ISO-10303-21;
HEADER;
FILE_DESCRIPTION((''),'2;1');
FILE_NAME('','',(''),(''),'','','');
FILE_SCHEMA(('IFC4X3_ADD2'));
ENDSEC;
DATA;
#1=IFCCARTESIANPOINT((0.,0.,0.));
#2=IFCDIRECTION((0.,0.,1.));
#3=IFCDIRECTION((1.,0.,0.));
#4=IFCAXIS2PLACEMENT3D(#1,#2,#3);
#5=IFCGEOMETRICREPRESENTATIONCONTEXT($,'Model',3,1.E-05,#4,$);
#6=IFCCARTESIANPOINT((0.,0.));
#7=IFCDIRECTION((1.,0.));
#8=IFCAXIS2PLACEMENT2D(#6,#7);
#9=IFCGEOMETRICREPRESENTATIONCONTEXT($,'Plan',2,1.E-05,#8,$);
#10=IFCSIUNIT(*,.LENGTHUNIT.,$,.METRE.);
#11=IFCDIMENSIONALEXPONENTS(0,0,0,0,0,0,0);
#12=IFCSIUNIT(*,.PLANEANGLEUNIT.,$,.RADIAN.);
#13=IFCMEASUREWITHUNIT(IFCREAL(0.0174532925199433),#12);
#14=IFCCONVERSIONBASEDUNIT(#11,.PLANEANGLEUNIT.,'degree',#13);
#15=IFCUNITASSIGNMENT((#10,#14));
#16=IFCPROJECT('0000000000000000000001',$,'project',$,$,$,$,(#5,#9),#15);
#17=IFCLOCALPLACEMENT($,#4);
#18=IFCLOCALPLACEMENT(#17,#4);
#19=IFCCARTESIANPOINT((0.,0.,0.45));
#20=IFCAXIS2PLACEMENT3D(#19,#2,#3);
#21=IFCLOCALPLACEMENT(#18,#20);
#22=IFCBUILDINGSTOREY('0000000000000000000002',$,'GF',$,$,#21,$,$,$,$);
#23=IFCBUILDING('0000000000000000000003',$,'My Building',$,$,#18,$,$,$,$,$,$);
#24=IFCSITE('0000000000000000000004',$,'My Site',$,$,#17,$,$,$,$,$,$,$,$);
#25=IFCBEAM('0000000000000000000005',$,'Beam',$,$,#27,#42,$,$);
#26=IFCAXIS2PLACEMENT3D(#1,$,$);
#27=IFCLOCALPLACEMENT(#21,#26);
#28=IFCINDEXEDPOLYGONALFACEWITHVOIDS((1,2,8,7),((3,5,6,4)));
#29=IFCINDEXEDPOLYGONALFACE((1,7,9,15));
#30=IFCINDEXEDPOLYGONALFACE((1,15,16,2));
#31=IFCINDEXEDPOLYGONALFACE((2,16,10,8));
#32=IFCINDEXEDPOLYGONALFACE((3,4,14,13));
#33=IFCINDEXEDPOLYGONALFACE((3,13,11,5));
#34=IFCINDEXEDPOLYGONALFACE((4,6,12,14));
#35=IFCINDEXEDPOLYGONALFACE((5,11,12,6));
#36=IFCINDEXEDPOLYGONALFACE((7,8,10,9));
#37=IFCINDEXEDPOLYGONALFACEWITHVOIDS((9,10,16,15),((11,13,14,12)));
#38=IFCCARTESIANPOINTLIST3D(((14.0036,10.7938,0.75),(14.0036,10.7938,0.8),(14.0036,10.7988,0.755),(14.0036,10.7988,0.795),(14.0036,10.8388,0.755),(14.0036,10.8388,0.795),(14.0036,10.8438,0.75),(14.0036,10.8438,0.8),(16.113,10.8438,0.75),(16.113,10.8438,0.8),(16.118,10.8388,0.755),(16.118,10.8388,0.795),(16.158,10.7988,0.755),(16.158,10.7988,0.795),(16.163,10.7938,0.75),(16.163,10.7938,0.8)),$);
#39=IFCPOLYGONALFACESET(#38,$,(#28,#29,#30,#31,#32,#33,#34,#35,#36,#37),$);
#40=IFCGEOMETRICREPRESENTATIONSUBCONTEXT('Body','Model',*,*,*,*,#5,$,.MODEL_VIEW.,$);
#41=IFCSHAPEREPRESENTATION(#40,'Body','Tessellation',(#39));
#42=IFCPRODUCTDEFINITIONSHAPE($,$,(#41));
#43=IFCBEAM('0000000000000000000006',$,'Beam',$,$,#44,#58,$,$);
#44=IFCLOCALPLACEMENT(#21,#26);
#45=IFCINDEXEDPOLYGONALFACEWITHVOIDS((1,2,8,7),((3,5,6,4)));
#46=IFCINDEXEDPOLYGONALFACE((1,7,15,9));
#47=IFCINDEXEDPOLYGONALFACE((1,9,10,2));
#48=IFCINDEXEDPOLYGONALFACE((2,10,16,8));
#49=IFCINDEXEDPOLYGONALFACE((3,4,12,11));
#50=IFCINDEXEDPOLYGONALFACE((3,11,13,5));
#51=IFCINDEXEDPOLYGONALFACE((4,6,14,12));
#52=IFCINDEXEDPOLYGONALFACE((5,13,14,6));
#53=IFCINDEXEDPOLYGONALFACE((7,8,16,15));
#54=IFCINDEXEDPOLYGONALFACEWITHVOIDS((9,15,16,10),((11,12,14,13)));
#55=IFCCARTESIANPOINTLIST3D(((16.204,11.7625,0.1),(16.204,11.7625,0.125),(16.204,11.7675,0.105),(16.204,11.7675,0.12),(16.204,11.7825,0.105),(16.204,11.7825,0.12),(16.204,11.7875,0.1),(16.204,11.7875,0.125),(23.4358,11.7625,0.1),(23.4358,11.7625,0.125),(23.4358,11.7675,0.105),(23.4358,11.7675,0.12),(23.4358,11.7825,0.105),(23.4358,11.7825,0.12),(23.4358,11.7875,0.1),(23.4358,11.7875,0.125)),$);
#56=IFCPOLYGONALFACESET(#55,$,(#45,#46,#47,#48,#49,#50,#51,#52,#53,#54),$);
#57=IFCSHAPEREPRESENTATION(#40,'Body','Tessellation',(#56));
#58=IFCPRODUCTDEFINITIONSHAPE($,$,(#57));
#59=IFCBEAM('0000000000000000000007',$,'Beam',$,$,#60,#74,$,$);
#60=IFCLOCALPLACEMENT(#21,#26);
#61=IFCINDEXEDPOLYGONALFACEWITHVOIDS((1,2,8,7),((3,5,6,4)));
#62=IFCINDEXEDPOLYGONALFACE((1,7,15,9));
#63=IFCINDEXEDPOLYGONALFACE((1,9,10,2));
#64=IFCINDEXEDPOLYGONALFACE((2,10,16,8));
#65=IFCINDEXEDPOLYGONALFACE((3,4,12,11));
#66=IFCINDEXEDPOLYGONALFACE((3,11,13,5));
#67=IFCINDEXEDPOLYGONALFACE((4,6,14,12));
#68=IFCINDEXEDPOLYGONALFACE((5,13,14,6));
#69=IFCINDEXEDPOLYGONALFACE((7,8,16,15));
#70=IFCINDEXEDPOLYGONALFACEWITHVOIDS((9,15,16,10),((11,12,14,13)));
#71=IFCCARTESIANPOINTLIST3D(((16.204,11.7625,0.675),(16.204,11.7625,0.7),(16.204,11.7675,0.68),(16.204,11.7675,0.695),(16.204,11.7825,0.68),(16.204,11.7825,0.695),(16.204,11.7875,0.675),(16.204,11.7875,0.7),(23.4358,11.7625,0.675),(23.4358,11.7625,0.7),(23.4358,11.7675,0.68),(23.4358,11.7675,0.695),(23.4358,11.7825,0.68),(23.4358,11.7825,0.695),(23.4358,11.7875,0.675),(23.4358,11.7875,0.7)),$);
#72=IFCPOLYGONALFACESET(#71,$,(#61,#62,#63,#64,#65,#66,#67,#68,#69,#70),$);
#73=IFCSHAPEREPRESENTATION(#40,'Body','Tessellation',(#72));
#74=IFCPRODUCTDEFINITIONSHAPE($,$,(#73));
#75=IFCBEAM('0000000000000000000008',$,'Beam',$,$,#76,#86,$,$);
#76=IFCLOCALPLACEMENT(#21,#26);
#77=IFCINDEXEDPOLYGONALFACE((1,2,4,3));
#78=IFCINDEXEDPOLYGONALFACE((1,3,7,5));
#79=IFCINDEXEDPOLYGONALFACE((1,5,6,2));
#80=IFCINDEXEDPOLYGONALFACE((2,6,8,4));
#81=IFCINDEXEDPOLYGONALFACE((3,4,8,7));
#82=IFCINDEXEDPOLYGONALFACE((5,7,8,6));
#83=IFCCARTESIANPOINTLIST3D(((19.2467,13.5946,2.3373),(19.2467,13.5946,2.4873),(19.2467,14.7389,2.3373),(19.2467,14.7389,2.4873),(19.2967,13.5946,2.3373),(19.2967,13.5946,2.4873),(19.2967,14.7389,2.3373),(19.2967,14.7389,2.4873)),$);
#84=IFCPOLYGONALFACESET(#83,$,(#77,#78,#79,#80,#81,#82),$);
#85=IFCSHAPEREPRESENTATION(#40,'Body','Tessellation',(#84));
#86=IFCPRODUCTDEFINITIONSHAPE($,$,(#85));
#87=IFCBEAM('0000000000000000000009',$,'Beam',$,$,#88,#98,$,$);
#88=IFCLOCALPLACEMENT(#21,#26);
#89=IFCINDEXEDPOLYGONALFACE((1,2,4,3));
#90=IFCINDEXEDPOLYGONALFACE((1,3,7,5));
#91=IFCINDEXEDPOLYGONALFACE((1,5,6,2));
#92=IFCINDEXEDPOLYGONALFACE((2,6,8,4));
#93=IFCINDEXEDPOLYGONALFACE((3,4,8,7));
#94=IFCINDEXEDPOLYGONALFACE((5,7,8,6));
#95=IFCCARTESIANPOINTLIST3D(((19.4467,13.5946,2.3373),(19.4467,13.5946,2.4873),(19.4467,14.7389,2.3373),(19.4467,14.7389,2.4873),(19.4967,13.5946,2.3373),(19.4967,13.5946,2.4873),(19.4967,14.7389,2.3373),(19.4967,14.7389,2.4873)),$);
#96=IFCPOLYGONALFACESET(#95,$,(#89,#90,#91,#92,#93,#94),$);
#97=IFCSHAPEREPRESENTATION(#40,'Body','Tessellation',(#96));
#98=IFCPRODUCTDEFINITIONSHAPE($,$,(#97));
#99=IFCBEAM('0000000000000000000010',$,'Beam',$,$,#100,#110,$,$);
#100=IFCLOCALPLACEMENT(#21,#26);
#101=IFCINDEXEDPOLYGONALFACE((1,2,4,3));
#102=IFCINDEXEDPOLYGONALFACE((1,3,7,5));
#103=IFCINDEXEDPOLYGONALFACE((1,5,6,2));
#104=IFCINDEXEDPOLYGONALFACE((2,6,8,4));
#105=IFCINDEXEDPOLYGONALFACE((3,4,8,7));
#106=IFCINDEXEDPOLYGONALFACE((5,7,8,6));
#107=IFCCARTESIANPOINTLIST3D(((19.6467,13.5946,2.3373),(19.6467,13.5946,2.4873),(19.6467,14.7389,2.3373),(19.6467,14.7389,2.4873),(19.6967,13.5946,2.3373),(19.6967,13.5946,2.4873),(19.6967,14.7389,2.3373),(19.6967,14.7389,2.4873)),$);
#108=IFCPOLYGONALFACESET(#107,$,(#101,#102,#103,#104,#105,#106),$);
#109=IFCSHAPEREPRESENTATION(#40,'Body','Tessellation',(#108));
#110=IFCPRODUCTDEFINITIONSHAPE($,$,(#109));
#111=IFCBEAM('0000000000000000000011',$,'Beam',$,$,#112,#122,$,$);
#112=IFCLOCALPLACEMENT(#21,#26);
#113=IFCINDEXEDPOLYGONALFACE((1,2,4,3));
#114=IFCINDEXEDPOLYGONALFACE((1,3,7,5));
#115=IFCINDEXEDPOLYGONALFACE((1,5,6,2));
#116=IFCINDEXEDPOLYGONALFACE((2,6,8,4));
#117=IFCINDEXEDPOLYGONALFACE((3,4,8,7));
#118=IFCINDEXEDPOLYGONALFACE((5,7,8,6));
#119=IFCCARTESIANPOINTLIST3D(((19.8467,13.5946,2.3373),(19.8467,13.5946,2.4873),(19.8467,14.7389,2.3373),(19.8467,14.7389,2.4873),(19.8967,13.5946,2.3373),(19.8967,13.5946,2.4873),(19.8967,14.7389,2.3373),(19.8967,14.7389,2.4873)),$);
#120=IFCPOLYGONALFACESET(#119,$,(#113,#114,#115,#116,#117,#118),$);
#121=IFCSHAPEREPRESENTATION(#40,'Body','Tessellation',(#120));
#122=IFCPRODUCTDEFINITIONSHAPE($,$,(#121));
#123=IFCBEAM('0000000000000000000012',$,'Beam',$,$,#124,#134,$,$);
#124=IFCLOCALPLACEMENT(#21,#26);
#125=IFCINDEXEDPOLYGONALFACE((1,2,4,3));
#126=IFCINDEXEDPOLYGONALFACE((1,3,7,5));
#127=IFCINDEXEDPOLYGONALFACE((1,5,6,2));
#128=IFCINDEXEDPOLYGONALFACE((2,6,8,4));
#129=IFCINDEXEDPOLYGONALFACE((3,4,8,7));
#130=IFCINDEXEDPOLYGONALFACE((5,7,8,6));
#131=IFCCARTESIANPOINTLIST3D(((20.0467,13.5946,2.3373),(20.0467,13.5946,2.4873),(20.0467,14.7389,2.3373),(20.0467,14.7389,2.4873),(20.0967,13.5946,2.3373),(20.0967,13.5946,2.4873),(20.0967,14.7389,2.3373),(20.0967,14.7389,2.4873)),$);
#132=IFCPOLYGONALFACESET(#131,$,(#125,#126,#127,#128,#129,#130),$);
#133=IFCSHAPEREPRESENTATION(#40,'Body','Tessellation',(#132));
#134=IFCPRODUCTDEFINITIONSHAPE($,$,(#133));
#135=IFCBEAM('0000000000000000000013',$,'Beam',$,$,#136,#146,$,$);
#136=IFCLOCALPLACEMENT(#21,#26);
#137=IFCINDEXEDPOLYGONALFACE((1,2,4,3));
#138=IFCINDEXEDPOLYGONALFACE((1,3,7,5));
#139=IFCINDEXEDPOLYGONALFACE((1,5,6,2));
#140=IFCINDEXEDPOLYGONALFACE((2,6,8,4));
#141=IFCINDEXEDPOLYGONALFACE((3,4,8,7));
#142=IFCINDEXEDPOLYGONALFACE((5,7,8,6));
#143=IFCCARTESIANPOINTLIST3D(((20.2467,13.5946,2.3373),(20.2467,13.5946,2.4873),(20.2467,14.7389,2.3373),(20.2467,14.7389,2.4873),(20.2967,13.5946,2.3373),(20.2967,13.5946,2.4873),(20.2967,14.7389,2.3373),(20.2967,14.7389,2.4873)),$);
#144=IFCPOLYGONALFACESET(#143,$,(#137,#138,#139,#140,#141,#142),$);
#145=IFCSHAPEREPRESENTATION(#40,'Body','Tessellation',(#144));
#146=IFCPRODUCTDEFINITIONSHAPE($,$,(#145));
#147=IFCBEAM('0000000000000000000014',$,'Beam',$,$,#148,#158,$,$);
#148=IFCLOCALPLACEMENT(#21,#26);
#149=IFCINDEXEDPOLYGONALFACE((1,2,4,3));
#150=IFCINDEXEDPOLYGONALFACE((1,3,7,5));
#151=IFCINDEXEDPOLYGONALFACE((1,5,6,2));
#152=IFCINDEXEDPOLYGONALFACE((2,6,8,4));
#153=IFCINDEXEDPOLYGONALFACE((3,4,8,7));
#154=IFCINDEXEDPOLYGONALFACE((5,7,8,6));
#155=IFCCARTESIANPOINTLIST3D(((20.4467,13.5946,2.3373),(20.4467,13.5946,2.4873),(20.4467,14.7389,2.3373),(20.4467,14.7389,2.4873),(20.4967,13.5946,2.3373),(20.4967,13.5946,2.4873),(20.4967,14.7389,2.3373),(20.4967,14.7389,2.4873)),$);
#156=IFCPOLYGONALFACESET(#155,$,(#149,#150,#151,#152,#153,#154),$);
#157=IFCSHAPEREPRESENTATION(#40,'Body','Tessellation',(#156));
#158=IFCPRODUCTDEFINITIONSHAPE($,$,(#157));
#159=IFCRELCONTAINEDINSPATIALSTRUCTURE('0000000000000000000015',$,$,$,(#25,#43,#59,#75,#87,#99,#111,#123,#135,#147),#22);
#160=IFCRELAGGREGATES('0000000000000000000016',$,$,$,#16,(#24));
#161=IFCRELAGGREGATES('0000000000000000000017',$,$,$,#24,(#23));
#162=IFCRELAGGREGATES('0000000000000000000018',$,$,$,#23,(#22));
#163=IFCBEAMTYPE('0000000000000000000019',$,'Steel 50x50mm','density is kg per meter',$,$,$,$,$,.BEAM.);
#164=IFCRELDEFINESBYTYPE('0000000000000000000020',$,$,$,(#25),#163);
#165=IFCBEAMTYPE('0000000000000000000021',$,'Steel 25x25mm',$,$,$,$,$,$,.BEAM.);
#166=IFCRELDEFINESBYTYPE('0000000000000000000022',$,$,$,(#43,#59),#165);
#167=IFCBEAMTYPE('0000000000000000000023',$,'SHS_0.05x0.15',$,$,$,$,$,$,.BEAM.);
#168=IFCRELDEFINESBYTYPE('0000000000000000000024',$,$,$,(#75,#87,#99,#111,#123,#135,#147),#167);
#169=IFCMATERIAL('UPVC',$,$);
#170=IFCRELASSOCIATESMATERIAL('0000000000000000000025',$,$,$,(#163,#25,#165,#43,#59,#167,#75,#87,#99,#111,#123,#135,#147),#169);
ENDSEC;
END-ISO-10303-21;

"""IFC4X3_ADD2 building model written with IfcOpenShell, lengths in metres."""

from ifc_helpers import new_model, entity, si_unit, converted_unit, frame, origin_with_axes, origin_2d_with_axis, place, context, subcontext, project, spatial, rectangle, hollow_rectangle, extrude, clip, halfspace, material, material_profile, profile_set, profile_usage, type_object, element, save


model = new_model("IFC4X3_ADD2")

# Units and contexts
model_context = context("Model", 3, precision=1e-05, world=origin_with_axes())
plan_context = context("Plan", 2, precision=1e-05, world=origin_2d_with_axis())
body_context = subcontext(model_context, "Body", "Model", "MODEL_VIEW")
ifc_project = project(units=[si_unit("LENGTHUNIT", "METRE"), converted_unit("PLANEANGLEUNIT", "degree", entity("IfcReal", 0.0174532925199433), si_unit("PLANEANGLEUNIT", "RADIAN"), dimensions=[0, 0, 0, 0, 0, 0, 0])], contexts=[model_context, plan_context])

# Site, building, storey
site_placement = place(None, origin_with_axes())
site = spatial("IfcSite", under=ifc_project, at=site_placement, Name="My Site")
building_placement = place(site_placement, origin_with_axes())
building = spatial("IfcBuilding", under=site, at=building_placement, Name="My Building")
storey_placement = place(building_placement, frame((0.0, 0.0, 0.45), z_axis=(0.0, 0.0, 1.0), x_axis=(1.0, 0.0, 0.0)))
storey = spatial("IfcBuildingStorey", under=building, at=storey_placement, Name="GF")

# Shared definitions
ifc_material = material(Name="UPVC")

# Beams
ifc_material_profile_1 = material_profile(ifc_material, hollow_rectangle(XDim=0.05, YDim=0.05, WallThickness=0.005))
ifc_profile_set_1 = profile_set([ifc_material_profile_1])
beam_type_1 = type_object("IfcBeamType", Name="Steel 50x50mm", Description="density is kg per meter", PredefinedType="BEAM", material=ifc_profile_set_1)
ifc_profile_usage_1 = profile_usage(ifc_profile_set_1)
beam_1_placement = place(storey_placement, frame((16.163, 10.8188, 0.775), z_axis=(-1.0, 0.0, 0.0), x_axis=(0.0, -1.0, 0.0)))
element("IfcBeam", 1, at=beam_1_placement, inside=storey, type_object=beam_type_1, material=ifc_profile_usage_1, Name="Beam", context=body_context, shape_type="Clipping", body=[
    clip(extrude(hollow_rectangle(XDim=0.05, YDim=0.05, WallThickness=0.005), origin_with_axes(), (0.0, 0.0, 1.0), 2.1594), halfspace(frame((0.025, -1.225, 0.0), z_axis=(-0.707107, 0.0, -0.707107), x_axis=(0.0, 1.0, 0.0)), False)),
])
ifc_material_profile_2 = material_profile(ifc_material, hollow_rectangle(XDim=0.025, YDim=0.025, WallThickness=0.005))
ifc_profile_set_2 = profile_set([ifc_material_profile_2])
ifc_profile_usage_2 = profile_usage(ifc_profile_set_2)
beam_type_2 = type_object("IfcBeamType", Name="Steel 25x25mm", PredefinedType="BEAM", material=ifc_profile_set_2)
beam_2_placement = place(storey_placement, frame((16.204, 11.775, 0.1125), z_axis=(1.0, 0.0, 0.0), x_axis=(0.0, 1.0, 0.0)))
element("IfcBeam", 2, at=beam_2_placement, inside=storey, type_object=beam_type_2, material=ifc_profile_usage_2, Name="Beam", context=body_context, shape_type="SweptSolid", body=[
    extrude(hollow_rectangle(XDim=0.025, YDim=0.025, WallThickness=0.005), origin_with_axes(), (0.0, 0.0, 1.0), 7.2317),
])
ifc_profile_usage_3 = profile_usage(ifc_profile_set_2)
beam_3_placement = place(storey_placement, frame((16.204, 11.775, 0.6875), z_axis=(1.0, 0.0, 0.0), x_axis=(0.0, 1.0, 0.0)))
element("IfcBeam", 3, at=beam_3_placement, inside=storey, type_object=beam_type_2, material=ifc_profile_usage_3, Name="Beam", context=body_context, shape_type="SweptSolid", body=[
    extrude(hollow_rectangle(XDim=0.025, YDim=0.025, WallThickness=0.005), origin_with_axes(), (0.0, 0.0, 1.0), 7.2317),
])
ifc_material_profile_3 = material_profile(ifc_material, rectangle(XDim=0.05, YDim=0.15))
ifc_profile_set_3 = profile_set([ifc_material_profile_3])
ifc_profile_usage_4 = profile_usage(ifc_profile_set_3)
beam_type_3 = type_object("IfcBeamType", Name="SHS_0.05x0.15", PredefinedType="BEAM", material=ifc_profile_set_3)
beam_4_placement = place(storey_placement, frame((19.2717, 14.7389, 2.4123), z_axis=(0.0, -1.0, 0.0), x_axis=(1.0, 0.0, 0.0)))
element("IfcBeam", 4, at=beam_4_placement, inside=storey, type_object=beam_type_3, material=ifc_profile_usage_4, Name="Beam", context=body_context, shape_type="SweptSolid", body=[
    extrude(rectangle(XDim=0.05, YDim=0.15), origin_with_axes(), (0.0, 0.0, 1.0), 1.1444),
])
ifc_profile_usage_5 = profile_usage(ifc_profile_set_3)
beam_5_placement = place(storey_placement, frame((19.4717, 14.7389, 2.4123), z_axis=(0.0, -1.0, 0.0), x_axis=(1.0, 0.0, 0.0)))
element("IfcBeam", 5, at=beam_5_placement, inside=storey, type_object=beam_type_3, material=ifc_profile_usage_5, Name="Beam", context=body_context, shape_type="SweptSolid", body=[
    extrude(rectangle(XDim=0.05, YDim=0.15), origin_with_axes(), (0.0, 0.0, 1.0), 1.1444),
])
ifc_profile_usage_6 = profile_usage(ifc_profile_set_3)
beam_6_placement = place(storey_placement, frame((19.6717, 14.7389, 2.4123), z_axis=(0.0, -1.0, 0.0), x_axis=(1.0, 0.0, 0.0)))
element("IfcBeam", 6, at=beam_6_placement, inside=storey, type_object=beam_type_3, material=ifc_profile_usage_6, Name="Beam", context=body_context, shape_type="SweptSolid", body=[
    extrude(rectangle(XDim=0.05, YDim=0.15), origin_with_axes(), (0.0, 0.0, 1.0), 1.1444),
])
ifc_profile_usage_7 = profile_usage(ifc_profile_set_3)
beam_7_placement = place(storey_placement, frame((19.8717, 14.7389, 2.4123), z_axis=(0.0, -1.0, 0.0), x_axis=(1.0, 0.0, 0.0)))
element("IfcBeam", 7, at=beam_7_placement, inside=storey, type_object=beam_type_3, material=ifc_profile_usage_7, Name="Beam", context=body_context, shape_type="SweptSolid", body=[
    extrude(rectangle(XDim=0.05, YDim=0.15), origin_with_axes(), (0.0, 0.0, 1.0), 1.1444),
])
ifc_profile_usage_8 = profile_usage(ifc_profile_set_3)
beam_8_placement = place(storey_placement, frame((20.0717, 14.7389, 2.4123), z_axis=(0.0, -1.0, 0.0), x_axis=(1.0, 0.0, 0.0)))
element("IfcBeam", 8, at=beam_8_placement, inside=storey, type_object=beam_type_3, material=ifc_profile_usage_8, Name="Beam", context=body_context, shape_type="SweptSolid", body=[
    extrude(rectangle(XDim=0.05, YDim=0.15), origin_with_axes(), (0.0, 0.0, 1.0), 1.1444),
])
ifc_profile_usage_9 = profile_usage(ifc_profile_set_3)
beam_9_placement = place(storey_placement, frame((20.2717, 14.7389, 2.4123), z_axis=(0.0, -1.0, 0.0), x_axis=(1.0, 0.0, 0.0)))
element("IfcBeam", 9, at=beam_9_placement, inside=storey, type_object=beam_type_3, material=ifc_profile_usage_9, Name="Beam", context=body_context, shape_type="SweptSolid", body=[
    extrude(rectangle(XDim=0.05, YDim=0.15), origin_with_axes(), (0.0, 0.0, 1.0), 1.1444),
])
ifc_profile_usage_10 = profile_usage(ifc_profile_set_3)
beam_10_placement = place(storey_placement, frame((20.4717, 14.7389, 2.4123), z_axis=(0.0, -1.0, 0.0), x_axis=(1.0, 0.0, 0.0)))
element("IfcBeam", 10, at=beam_10_placement, inside=storey, type_object=beam_type_3, material=ifc_profile_usage_10, Name="Beam", context=body_context, shape_type="SweptSolid", body=[
    extrude(rectangle(XDim=0.05, YDim=0.15), origin_with_axes(), (0.0, 0.0, 1.0), 1.1444),
])

save(model, "model.ifc")
